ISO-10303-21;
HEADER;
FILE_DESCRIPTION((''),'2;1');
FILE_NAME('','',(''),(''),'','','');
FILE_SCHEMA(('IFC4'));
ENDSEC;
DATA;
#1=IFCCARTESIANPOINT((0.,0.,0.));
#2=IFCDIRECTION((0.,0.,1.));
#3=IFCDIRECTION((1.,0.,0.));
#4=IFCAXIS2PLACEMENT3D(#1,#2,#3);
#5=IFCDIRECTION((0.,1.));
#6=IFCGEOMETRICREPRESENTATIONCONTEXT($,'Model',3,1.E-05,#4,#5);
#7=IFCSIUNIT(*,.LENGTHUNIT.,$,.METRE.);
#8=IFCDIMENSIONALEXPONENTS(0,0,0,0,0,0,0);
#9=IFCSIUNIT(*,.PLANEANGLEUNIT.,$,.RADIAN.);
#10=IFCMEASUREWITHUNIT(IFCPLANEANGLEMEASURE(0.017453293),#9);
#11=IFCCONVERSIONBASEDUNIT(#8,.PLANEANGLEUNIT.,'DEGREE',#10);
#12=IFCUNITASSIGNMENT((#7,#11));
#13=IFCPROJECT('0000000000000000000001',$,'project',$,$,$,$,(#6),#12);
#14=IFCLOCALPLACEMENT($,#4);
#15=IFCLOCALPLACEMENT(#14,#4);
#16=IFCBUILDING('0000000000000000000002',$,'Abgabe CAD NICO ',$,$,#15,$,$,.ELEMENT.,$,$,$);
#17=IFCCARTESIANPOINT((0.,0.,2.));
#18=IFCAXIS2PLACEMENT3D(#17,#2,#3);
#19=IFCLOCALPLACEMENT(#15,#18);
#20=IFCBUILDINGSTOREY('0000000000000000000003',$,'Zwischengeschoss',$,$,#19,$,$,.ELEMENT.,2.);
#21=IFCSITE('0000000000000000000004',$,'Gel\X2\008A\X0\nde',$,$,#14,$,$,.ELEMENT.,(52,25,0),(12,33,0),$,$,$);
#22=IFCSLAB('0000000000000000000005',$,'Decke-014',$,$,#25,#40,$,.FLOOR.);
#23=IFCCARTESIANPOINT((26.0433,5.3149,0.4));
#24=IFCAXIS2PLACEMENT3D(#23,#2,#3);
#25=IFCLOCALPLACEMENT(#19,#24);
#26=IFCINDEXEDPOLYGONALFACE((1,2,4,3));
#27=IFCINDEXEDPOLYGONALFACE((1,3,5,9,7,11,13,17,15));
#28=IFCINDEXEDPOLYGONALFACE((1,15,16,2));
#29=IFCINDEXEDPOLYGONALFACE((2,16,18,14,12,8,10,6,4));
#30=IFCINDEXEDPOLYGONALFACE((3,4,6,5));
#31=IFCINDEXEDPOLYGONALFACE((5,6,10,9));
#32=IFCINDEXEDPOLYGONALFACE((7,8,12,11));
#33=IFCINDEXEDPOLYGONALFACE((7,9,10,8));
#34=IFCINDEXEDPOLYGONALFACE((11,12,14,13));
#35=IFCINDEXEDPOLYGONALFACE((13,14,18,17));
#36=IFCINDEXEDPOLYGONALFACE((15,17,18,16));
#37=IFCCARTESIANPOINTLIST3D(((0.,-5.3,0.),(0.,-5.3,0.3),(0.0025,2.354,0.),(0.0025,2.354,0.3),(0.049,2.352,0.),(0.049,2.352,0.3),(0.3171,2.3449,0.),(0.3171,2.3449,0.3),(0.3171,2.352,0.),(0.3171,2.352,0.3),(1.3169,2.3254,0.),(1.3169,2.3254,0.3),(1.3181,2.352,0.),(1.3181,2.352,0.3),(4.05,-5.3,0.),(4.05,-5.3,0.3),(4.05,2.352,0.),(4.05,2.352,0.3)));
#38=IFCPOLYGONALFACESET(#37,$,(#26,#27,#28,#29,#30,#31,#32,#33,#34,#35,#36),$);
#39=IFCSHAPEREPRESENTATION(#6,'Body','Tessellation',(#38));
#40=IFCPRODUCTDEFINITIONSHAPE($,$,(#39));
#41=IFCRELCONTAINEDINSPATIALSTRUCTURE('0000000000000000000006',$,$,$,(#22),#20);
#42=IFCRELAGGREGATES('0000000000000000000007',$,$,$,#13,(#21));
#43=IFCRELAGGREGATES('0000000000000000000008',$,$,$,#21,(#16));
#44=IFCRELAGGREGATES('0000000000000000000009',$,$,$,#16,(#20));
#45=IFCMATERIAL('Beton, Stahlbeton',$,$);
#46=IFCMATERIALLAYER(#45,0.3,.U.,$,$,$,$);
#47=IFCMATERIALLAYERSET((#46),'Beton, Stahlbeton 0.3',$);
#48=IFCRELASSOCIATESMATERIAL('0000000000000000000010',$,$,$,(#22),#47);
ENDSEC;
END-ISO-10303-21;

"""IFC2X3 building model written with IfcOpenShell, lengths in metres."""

from ifc_helpers import new_model, entity, si_unit, converted_unit, direction, frame, origin_with_axes, place, context, project, spatial, polyline, outline, extrude, material, layer, layer_set, layer_usage, element, save


model = new_model("IFC2X3")

# Units and contexts
model_context = context("Model", 3, precision=1e-05, world=origin_with_axes(), true_north=direction((0.0, 1.0)))
ifc_project = project(units=[si_unit("LENGTHUNIT", "METRE"), converted_unit("PLANEANGLEUNIT", "DEGREE", entity("IfcPlaneAngleMeasure", 0.017453293), si_unit("PLANEANGLEUNIT", "RADIAN"), dimensions=[0, 0, 0, 0, 0, 0, 0])], contexts=[model_context])

# Site, building, storey
site_placement = place(None, origin_with_axes())
site = spatial("IfcSite", under=ifc_project, at=site_placement, Name="Gel\u008ande", CompositionType="ELEMENT", RefLatitude=(52, 25, 0), RefLongitude=(12, 33, 0))
building_placement = place(site_placement, origin_with_axes())
building = spatial("IfcBuilding", under=site, at=building_placement, Name="Abgabe CAD NICO ", CompositionType="ELEMENT")
storey_placement = place(building_placement, frame((0.0, 0.0, 2.0), z_axis=(0.0, 0.0, 1.0), x_axis=(1.0, 0.0, 0.0)))
storey = spatial("IfcBuildingStorey", under=building, at=storey_placement, Name="Zwischengeschoss", CompositionType="ELEMENT", Elevation=2.0)

# Slab
ifc_material_1 = material(Name="Beton, Stahlbeton")
ifc_layer_1 = layer(ifc_material_1, 0.3, ventilated="UNKNOWN")
ifc_layer_set_1 = layer_set([ifc_layer_1], Name="Beton, Stahlbeton 0.3")
ifc_layer_usage_1 = layer_usage(ifc_layer_set_1, "AXIS3", "NEGATIVE", 0.3)
slab_placement = place(storey_placement, frame((26.0433, 5.3149, 0.4), z_axis=(0.0, 0.0, 1.0), x_axis=(1.0, 0.0, 0.0)))
element("IfcSlab", 1, at=slab_placement, inside=storey, material=ifc_layer_usage_1, Name="Decke-014", PredefinedType="FLOOR", context=model_context, shape_type="SweptSolid", body=[
    extrude(outline(polyline([(0.0, -5.3), (4.05, -5.3), (4.05, 2.352), (1.3181, 2.352), (1.3169, 2.3254), (0.3171, 2.3449), (0.3171, 2.352), (0.049, 2.352), (0.0025, 2.354), (0.0, -5.3)])), origin_with_axes(), (0.0, 0.0, 1.0), 0.3),
])

save(model, "model.ifc")
